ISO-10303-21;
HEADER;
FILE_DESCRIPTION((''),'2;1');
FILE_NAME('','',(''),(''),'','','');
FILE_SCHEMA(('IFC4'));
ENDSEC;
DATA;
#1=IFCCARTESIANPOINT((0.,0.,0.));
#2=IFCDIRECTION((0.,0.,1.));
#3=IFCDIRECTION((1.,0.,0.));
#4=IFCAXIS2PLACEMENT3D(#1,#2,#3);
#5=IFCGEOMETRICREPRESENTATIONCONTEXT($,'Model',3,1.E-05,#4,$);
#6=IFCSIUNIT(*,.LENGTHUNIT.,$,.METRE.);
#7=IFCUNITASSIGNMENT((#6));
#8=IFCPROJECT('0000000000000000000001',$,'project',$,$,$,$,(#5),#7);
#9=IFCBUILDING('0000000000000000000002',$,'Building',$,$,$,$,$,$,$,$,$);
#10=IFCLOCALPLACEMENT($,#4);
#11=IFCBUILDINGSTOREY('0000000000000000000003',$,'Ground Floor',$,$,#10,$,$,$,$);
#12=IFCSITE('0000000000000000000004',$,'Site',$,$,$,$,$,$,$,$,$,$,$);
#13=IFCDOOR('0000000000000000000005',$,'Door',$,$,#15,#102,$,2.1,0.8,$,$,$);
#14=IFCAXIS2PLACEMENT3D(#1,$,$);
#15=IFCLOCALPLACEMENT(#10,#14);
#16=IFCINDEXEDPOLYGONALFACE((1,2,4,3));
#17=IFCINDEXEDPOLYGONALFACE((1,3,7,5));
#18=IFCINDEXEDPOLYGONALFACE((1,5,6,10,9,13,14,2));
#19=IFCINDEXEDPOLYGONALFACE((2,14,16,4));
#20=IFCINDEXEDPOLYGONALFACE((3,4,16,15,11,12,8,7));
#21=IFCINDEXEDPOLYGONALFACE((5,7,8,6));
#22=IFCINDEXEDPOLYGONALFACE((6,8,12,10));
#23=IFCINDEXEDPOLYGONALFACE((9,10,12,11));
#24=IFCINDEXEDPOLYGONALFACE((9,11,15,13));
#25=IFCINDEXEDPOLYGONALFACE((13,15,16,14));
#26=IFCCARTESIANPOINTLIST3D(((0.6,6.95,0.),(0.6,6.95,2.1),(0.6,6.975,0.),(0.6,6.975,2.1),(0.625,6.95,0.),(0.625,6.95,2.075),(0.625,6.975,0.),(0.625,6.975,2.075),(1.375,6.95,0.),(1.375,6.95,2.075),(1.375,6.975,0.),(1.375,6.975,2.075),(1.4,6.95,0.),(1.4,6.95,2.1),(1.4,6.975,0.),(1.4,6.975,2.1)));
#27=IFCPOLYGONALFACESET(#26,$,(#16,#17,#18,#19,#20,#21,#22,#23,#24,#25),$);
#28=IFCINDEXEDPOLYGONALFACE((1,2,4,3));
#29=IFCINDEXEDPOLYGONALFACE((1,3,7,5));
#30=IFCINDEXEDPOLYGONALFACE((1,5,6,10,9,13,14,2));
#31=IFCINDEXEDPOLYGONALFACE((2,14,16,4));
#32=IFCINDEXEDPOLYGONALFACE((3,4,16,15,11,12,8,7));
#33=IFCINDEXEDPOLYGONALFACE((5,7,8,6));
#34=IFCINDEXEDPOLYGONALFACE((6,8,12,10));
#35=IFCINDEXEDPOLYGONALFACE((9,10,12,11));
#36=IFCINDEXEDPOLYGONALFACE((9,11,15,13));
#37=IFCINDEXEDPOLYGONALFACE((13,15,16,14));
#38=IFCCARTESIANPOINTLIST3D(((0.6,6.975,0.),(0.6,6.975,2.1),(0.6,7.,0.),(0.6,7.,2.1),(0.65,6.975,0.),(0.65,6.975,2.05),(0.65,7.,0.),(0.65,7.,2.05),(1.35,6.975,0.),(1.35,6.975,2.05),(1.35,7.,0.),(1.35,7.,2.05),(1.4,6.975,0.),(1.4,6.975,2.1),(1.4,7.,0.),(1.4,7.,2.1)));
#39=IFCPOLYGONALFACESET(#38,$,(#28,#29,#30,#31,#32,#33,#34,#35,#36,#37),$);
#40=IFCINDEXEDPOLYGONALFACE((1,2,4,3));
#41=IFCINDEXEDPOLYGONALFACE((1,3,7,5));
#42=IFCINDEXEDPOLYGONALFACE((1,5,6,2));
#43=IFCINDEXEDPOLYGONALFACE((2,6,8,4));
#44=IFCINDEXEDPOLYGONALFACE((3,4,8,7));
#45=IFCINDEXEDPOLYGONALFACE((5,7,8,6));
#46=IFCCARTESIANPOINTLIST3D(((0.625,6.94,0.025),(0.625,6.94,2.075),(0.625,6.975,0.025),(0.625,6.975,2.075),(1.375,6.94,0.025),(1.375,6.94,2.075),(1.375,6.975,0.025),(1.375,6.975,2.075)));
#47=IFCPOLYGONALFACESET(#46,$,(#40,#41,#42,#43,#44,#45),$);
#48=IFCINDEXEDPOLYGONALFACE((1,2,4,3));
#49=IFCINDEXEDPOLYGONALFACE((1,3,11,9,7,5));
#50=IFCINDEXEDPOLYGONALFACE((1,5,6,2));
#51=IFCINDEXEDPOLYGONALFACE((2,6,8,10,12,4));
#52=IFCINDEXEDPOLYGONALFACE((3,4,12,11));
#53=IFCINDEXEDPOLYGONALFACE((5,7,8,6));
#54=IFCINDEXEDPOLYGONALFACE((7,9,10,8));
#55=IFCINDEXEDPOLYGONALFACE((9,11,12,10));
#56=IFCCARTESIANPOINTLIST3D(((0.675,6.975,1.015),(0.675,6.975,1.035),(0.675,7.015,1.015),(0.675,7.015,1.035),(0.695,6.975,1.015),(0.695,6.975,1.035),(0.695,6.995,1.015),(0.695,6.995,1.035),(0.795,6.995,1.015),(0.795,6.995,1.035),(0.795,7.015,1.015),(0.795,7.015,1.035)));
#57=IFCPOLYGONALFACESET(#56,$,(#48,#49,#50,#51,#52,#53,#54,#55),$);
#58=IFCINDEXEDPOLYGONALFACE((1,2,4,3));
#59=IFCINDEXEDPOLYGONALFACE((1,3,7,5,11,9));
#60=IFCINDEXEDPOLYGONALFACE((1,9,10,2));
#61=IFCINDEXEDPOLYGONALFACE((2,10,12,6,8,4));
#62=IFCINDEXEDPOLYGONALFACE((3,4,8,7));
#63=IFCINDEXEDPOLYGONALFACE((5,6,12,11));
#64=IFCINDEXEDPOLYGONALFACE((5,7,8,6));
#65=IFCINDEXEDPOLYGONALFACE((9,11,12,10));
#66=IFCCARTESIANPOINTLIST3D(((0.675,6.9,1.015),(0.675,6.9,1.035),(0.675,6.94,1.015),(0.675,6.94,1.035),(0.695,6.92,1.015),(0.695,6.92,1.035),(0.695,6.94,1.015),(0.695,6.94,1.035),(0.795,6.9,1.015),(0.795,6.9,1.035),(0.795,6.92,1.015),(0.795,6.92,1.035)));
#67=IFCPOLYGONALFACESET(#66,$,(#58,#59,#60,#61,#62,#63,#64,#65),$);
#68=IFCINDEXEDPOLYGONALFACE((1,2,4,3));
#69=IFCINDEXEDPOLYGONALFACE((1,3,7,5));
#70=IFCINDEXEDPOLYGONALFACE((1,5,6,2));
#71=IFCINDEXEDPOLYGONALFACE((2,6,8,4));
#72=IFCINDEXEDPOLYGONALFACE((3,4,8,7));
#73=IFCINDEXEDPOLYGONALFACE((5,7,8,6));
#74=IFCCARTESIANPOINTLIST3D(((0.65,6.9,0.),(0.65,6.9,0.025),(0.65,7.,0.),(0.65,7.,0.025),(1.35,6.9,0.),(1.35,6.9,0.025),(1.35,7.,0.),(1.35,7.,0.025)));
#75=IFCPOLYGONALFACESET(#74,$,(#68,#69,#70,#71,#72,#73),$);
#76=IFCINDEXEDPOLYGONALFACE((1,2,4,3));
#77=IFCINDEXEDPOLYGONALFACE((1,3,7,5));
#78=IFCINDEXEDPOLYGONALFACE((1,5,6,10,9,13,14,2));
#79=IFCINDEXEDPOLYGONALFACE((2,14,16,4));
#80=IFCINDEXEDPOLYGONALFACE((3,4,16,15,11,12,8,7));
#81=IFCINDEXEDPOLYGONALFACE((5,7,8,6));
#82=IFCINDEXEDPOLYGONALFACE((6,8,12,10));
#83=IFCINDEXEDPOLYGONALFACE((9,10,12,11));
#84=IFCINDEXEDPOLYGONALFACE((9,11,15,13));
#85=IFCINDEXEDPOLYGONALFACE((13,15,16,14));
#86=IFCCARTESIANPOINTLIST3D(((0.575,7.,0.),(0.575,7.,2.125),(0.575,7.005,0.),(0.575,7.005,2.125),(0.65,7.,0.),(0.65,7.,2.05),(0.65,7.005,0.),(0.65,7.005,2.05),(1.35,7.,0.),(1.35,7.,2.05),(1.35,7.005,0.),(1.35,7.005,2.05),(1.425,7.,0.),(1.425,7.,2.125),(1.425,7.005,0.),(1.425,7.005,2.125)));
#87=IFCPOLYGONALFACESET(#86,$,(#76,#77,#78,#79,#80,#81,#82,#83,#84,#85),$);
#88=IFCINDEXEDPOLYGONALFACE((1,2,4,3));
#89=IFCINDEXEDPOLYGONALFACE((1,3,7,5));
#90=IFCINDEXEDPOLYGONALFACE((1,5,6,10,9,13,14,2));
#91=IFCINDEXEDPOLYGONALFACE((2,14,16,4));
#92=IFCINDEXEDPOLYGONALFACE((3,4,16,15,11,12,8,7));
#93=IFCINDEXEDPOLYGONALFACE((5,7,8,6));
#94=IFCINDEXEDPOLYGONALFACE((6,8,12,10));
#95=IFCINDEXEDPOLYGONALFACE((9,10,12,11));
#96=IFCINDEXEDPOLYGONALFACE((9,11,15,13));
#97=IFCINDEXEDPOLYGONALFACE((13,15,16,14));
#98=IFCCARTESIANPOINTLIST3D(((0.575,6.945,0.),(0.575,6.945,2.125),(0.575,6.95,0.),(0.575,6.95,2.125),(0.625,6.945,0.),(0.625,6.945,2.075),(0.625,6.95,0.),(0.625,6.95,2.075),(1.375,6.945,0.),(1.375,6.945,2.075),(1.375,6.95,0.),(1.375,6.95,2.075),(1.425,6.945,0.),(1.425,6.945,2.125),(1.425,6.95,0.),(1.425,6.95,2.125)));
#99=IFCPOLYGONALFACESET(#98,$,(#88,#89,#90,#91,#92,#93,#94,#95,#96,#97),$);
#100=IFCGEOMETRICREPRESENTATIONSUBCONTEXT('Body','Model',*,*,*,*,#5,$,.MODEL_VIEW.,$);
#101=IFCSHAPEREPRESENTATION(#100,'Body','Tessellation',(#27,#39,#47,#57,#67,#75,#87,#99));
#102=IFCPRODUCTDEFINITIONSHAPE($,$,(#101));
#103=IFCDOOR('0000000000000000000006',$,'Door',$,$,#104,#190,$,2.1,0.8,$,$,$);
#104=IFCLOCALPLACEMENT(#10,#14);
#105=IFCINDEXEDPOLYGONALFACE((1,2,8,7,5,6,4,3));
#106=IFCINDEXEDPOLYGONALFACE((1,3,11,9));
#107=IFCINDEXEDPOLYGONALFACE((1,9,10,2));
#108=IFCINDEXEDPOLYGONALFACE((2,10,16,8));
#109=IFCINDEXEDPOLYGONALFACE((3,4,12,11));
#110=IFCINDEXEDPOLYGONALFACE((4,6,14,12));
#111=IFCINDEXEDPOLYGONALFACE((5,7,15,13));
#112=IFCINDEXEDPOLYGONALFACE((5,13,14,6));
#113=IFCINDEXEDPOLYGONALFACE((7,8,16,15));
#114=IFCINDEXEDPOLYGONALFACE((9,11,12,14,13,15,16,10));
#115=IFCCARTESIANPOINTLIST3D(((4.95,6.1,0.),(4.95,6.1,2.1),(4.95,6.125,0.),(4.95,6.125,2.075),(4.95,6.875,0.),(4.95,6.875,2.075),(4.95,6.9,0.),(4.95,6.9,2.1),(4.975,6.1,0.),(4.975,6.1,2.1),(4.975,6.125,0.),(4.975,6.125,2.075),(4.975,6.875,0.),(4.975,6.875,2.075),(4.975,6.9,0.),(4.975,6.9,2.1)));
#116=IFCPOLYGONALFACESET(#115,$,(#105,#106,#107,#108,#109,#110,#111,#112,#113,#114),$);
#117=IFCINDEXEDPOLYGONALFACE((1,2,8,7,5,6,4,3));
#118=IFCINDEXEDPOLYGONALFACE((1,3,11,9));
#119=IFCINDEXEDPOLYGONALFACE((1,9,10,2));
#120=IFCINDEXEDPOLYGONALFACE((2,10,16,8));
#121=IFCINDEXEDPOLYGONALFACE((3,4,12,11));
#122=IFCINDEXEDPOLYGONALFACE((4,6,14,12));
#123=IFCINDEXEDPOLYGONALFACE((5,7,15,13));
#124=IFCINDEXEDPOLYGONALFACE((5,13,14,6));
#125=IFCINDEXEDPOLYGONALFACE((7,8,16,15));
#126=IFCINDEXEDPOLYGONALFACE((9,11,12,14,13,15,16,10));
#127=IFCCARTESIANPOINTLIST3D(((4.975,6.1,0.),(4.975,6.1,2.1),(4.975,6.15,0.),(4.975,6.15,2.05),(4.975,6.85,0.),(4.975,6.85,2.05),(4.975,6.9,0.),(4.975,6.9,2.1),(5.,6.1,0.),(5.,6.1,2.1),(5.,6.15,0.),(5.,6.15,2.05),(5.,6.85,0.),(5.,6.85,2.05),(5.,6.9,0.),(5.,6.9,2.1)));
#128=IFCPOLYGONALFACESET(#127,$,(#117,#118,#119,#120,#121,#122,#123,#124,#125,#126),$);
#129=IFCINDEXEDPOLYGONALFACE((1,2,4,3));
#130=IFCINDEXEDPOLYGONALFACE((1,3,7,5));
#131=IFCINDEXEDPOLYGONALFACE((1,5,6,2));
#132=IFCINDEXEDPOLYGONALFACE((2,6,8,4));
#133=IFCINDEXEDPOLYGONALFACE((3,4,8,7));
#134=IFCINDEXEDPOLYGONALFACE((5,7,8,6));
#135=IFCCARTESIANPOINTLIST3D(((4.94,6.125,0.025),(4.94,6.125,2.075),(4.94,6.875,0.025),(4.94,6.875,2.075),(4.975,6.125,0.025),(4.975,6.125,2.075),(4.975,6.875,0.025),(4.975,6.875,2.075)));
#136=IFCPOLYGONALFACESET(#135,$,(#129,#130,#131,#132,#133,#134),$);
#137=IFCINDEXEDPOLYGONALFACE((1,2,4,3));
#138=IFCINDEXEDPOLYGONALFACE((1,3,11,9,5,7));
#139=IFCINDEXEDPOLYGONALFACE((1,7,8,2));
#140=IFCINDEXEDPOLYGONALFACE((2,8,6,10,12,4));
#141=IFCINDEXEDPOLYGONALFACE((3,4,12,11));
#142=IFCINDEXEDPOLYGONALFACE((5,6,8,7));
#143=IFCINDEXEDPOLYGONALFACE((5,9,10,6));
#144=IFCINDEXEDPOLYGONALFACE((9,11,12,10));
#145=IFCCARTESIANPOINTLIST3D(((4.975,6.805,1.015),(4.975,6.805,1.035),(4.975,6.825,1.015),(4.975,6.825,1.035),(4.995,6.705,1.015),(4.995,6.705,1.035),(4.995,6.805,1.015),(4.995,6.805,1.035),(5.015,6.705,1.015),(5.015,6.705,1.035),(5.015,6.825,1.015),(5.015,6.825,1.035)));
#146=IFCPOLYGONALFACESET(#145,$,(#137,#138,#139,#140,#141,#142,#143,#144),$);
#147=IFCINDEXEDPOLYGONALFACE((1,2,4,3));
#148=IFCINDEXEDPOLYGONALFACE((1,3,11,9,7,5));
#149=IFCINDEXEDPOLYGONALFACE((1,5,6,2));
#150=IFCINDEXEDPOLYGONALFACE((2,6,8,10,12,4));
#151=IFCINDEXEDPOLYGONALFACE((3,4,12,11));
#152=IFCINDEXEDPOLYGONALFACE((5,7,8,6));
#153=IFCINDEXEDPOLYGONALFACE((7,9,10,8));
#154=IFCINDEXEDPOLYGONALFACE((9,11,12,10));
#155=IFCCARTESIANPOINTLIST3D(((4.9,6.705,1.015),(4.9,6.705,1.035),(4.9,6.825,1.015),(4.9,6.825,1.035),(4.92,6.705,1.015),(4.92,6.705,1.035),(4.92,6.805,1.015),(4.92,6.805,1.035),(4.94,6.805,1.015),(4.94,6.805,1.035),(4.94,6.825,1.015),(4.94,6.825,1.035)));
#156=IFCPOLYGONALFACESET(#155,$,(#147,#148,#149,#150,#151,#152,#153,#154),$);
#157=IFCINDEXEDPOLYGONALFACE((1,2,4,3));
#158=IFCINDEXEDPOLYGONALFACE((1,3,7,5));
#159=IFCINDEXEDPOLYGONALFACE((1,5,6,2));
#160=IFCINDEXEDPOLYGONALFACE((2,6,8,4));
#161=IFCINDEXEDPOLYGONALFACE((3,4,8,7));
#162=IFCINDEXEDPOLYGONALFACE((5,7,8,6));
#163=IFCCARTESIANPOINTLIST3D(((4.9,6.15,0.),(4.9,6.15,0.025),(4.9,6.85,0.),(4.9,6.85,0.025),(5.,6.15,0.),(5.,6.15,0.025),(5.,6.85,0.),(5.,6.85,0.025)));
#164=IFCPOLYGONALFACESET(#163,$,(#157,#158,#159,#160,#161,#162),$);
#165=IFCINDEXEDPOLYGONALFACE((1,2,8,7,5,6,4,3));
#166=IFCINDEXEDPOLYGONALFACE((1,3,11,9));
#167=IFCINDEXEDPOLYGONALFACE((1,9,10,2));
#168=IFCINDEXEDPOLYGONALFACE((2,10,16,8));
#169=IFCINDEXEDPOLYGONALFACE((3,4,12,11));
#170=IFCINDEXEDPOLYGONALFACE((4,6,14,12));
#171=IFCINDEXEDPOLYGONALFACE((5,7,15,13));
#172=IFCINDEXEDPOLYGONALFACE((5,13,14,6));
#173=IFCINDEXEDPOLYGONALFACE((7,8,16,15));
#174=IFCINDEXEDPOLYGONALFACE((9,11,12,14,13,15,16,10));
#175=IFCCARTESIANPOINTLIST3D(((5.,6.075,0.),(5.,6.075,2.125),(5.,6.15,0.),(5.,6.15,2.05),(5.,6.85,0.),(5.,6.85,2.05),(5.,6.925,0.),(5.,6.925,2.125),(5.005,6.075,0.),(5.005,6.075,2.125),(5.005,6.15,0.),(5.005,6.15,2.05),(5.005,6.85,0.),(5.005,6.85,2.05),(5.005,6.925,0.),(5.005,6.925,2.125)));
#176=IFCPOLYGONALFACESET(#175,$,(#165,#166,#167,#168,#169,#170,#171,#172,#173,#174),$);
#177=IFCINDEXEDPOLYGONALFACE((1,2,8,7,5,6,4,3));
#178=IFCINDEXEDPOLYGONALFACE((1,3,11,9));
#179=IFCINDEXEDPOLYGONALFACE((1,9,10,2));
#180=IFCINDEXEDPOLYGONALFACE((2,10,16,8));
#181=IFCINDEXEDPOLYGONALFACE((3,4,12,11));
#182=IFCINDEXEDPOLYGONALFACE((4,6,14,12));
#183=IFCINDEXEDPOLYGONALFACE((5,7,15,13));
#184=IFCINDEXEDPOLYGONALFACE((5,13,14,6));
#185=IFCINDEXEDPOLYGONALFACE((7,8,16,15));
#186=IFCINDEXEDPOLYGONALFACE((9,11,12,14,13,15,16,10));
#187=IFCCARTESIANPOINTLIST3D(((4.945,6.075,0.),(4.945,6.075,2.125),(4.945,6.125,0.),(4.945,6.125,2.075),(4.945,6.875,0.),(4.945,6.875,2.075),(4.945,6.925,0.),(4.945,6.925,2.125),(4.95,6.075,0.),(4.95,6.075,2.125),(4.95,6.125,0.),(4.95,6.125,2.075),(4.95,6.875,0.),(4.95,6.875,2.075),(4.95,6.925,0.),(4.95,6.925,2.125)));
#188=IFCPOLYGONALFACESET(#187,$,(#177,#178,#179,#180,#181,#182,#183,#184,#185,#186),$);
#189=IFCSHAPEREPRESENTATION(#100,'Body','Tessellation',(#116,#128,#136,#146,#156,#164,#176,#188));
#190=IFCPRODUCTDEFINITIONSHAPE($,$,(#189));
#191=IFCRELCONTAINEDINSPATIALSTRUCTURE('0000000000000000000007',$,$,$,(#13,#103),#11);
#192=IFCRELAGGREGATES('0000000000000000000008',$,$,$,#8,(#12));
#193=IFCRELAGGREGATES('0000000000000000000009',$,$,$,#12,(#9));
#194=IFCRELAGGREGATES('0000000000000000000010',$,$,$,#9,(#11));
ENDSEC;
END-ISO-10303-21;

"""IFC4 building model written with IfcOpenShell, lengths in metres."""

from ifc_helpers import new_model, si_unit, frame, origin_with_axes, place, context, subcontext, project, spatial, line, indexed_curve, outline, extrude, element, save


model = new_model("IFC4")

# Units and contexts
model_context = context("Model", 3, precision=1e-05, world=origin_with_axes())
body_context = subcontext(model_context, "Body", "Model", "MODEL_VIEW")
ifc_project = project(units=[si_unit("LENGTHUNIT", "METRE")], contexts=[model_context])

# Site, building, storey
site = spatial("IfcSite", under=ifc_project, Name="Site")
building = spatial("IfcBuilding", under=site, Name="Building")
storey_placement = place(None, origin_with_axes())
storey = spatial("IfcBuildingStorey", under=building, at=storey_placement, Name="Ground Floor")

# Doors
door_1_placement = place(storey_placement, frame((1.4, 7.0, 0.0), z_axis=(0.0, 0.0, 1.0), x_axis=(-1.0, 0.0, 0.0)))
element("IfcDoor", 1, at=door_1_placement, inside=storey, Name="Door", OverallHeight=2.1, OverallWidth=0.8, context=body_context, shape_type="SweptSolid", body=[
    extrude(outline(indexed_curve([(0.0, 0.0), (0.0, 2.1), (0.8, 2.1), (0.8, 0.0), (0.775, 0.0), (0.775, 2.075), (0.025, 2.075), (0.025, 0.0)], segments=[line(1, 2, 3, 4, 5, 6, 7, 8, 1)])), frame((0.0, 0.025, 0.0), z_axis=(0.0, -1.0, 0.0), x_axis=(1.0, 0.0, 0.0)), (0.0, 0.0, -1.0), 0.025),
    extrude(outline(indexed_curve([(0.0, 0.0), (0.0, 2.1), (0.8, 2.1), (0.8, 0.0), (0.75, 0.0), (0.75, 2.05), (0.05, 2.05), (0.05, 0.0)], segments=[line(1, 2, 3, 4, 5, 6, 7, 8, 1)])), frame((0.0, 0.0, 0.0), z_axis=(0.0, -1.0, 0.0), x_axis=(1.0, 0.0, 0.0)), (0.0, 0.0, -1.0), 0.025),
    extrude(outline(indexed_curve([(0.0, 0.0), (0.75, 0.0), (0.75, 0.035), (0.0, 0.035)], segments=[line(1, 2, 3, 4, 1)])), frame((0.025, 0.025, 0.025), z_axis=(0.0, 0.0, 1.0), x_axis=(1.0, 0.0, 0.0)), (0.0, 0.0, 1.0), 2.05),
    extrude(outline(indexed_curve([(0.0, 0.0), (0.0, -0.04), (-0.12, -0.04), (-0.12, -0.02), (-0.02, -0.02), (-0.02, 0.0)], segments=[line(1, 2, 3, 4, 5, 6, 1)])), frame((0.725, 0.025, 1.015), z_axis=(0.0, 0.0, 1.0), x_axis=(1.0, 0.0, 0.0)), (0.0, 0.0, 1.0), 0.02),
    extrude(outline(indexed_curve([(0.0, 0.0), (0.0, 0.04), (-0.12, 0.04), (-0.12, 0.02), (-0.02, 0.02), (-0.02, 0.0)], segments=[line(1, 2, 3, 4, 5, 6, 1)])), frame((0.725, 0.06, 1.015), z_axis=(0.0, 0.0, 1.0), x_axis=(1.0, 0.0, 0.0)), (0.0, 0.0, 1.0), 0.02),
    extrude(outline(indexed_curve([(0.0, 0.0), (0.7, 0.0), (0.7, 0.1), (0.0, 0.1)], segments=[line(1, 2, 3, 4, 1)])), frame((0.05, 0.0, 0.0), z_axis=(0.0, 0.0, 1.0), x_axis=(1.0, 0.0, 0.0)), (0.0, 0.0, 1.0), 0.025),
    extrude(outline(indexed_curve([(0.0, 0.0), (0.0, 2.125), (0.85, 2.125), (0.85, 0.0), (0.775, 0.0), (0.775, 2.05), (0.075, 2.05), (0.075, 0.0)], segments=[line(1, 2, 3, 4, 5, 6, 7, 8, 1)])), frame((-0.025, -0.005, 0.0), z_axis=(0.0, -1.0, 0.0), x_axis=(1.0, 0.0, 0.0)), (0.0, 0.0, -1.0), 0.005),
    extrude(outline(indexed_curve([(0.0, 0.0), (0.0, 2.125), (0.85, 2.125), (0.85, 0.0), (0.8, 0.0), (0.8, 2.075), (0.05, 2.075), (0.05, 0.0)], segments=[line(1, 2, 3, 4, 5, 6, 7, 8, 1)])), frame((-0.025, 0.05, 0.0), z_axis=(0.0, -1.0, 0.0), x_axis=(1.0, 0.0, 0.0)), (0.0, 0.0, -1.0), 0.005),
])
door_2_placement = place(storey_placement, frame((5.0, 6.1, 0.0), z_axis=(0.0, 0.0, 1.0), x_axis=(0.0, 1.0, 0.0)))
element("IfcDoor", 2, at=door_2_placement, inside=storey, Name="Door", OverallHeight=2.1, OverallWidth=0.8, context=body_context, shape_type="SweptSolid", body=[
    extrude(outline(indexed_curve([(0.0, 0.0), (0.0, 2.1), (0.8, 2.1), (0.8, 0.0), (0.775, 0.0), (0.775, 2.075), (0.025, 2.075), (0.025, 0.0)], segments=[line(1, 2, 3, 4, 5, 6, 7, 8, 1)])), frame((0.0, 0.025, 0.0), z_axis=(0.0, -1.0, 0.0), x_axis=(1.0, 0.0, 0.0)), (0.0, 0.0, -1.0), 0.025),
    extrude(outline(indexed_curve([(0.0, 0.0), (0.0, 2.1), (0.8, 2.1), (0.8, 0.0), (0.75, 0.0), (0.75, 2.05), (0.05, 2.05), (0.05, 0.0)], segments=[line(1, 2, 3, 4, 5, 6, 7, 8, 1)])), frame((0.0, 0.0, 0.0), z_axis=(0.0, -1.0, 0.0), x_axis=(1.0, 0.0, 0.0)), (0.0, 0.0, -1.0), 0.025),
    extrude(outline(indexed_curve([(0.0, 0.0), (0.75, 0.0), (0.75, 0.035), (0.0, 0.035)], segments=[line(1, 2, 3, 4, 1)])), frame((0.025, 0.025, 0.025), z_axis=(0.0, 0.0, 1.0), x_axis=(1.0, 0.0, 0.0)), (0.0, 0.0, 1.0), 2.05),
    extrude(outline(indexed_curve([(0.0, 0.0), (0.0, -0.04), (-0.12, -0.04), (-0.12, -0.02), (-0.02, -0.02), (-0.02, 0.0)], segments=[line(1, 2, 3, 4, 5, 6, 1)])), frame((0.725, 0.025, 1.015), z_axis=(0.0, 0.0, 1.0), x_axis=(1.0, 0.0, 0.0)), (0.0, 0.0, 1.0), 0.02),
    extrude(outline(indexed_curve([(0.0, 0.0), (0.0, 0.04), (-0.12, 0.04), (-0.12, 0.02), (-0.02, 0.02), (-0.02, 0.0)], segments=[line(1, 2, 3, 4, 5, 6, 1)])), frame((0.725, 0.06, 1.015), z_axis=(0.0, 0.0, 1.0), x_axis=(1.0, 0.0, 0.0)), (0.0, 0.0, 1.0), 0.02),
    extrude(outline(indexed_curve([(0.0, 0.0), (0.7, 0.0), (0.7, 0.1), (0.0, 0.1)], segments=[line(1, 2, 3, 4, 1)])), frame((0.05, 0.0, 0.0), z_axis=(0.0, 0.0, 1.0), x_axis=(1.0, 0.0, 0.0)), (0.0, 0.0, 1.0), 0.025),
    extrude(outline(indexed_curve([(0.0, 0.0), (0.0, 2.125), (0.85, 2.125), (0.85, 0.0), (0.775, 0.0), (0.775, 2.05), (0.075, 2.05), (0.075, 0.0)], segments=[line(1, 2, 3, 4, 5, 6, 7, 8, 1)])), frame((-0.025, -0.005, 0.0), z_axis=(0.0, -1.0, 0.0), x_axis=(1.0, 0.0, 0.0)), (0.0, 0.0, -1.0), 0.005),
    extrude(outline(indexed_curve([(0.0, 0.0), (0.0, 2.125), (0.85, 2.125), (0.85, 0.0), (0.8, 0.0), (0.8, 2.075), (0.05, 2.075), (0.05, 0.0)], segments=[line(1, 2, 3, 4, 5, 6, 7, 8, 1)])), frame((-0.025, 0.05, 0.0), z_axis=(0.0, -1.0, 0.0), x_axis=(1.0, 0.0, 0.0)), (0.0, 0.0, -1.0), 0.005),
])

save(model, "model.ifc")
